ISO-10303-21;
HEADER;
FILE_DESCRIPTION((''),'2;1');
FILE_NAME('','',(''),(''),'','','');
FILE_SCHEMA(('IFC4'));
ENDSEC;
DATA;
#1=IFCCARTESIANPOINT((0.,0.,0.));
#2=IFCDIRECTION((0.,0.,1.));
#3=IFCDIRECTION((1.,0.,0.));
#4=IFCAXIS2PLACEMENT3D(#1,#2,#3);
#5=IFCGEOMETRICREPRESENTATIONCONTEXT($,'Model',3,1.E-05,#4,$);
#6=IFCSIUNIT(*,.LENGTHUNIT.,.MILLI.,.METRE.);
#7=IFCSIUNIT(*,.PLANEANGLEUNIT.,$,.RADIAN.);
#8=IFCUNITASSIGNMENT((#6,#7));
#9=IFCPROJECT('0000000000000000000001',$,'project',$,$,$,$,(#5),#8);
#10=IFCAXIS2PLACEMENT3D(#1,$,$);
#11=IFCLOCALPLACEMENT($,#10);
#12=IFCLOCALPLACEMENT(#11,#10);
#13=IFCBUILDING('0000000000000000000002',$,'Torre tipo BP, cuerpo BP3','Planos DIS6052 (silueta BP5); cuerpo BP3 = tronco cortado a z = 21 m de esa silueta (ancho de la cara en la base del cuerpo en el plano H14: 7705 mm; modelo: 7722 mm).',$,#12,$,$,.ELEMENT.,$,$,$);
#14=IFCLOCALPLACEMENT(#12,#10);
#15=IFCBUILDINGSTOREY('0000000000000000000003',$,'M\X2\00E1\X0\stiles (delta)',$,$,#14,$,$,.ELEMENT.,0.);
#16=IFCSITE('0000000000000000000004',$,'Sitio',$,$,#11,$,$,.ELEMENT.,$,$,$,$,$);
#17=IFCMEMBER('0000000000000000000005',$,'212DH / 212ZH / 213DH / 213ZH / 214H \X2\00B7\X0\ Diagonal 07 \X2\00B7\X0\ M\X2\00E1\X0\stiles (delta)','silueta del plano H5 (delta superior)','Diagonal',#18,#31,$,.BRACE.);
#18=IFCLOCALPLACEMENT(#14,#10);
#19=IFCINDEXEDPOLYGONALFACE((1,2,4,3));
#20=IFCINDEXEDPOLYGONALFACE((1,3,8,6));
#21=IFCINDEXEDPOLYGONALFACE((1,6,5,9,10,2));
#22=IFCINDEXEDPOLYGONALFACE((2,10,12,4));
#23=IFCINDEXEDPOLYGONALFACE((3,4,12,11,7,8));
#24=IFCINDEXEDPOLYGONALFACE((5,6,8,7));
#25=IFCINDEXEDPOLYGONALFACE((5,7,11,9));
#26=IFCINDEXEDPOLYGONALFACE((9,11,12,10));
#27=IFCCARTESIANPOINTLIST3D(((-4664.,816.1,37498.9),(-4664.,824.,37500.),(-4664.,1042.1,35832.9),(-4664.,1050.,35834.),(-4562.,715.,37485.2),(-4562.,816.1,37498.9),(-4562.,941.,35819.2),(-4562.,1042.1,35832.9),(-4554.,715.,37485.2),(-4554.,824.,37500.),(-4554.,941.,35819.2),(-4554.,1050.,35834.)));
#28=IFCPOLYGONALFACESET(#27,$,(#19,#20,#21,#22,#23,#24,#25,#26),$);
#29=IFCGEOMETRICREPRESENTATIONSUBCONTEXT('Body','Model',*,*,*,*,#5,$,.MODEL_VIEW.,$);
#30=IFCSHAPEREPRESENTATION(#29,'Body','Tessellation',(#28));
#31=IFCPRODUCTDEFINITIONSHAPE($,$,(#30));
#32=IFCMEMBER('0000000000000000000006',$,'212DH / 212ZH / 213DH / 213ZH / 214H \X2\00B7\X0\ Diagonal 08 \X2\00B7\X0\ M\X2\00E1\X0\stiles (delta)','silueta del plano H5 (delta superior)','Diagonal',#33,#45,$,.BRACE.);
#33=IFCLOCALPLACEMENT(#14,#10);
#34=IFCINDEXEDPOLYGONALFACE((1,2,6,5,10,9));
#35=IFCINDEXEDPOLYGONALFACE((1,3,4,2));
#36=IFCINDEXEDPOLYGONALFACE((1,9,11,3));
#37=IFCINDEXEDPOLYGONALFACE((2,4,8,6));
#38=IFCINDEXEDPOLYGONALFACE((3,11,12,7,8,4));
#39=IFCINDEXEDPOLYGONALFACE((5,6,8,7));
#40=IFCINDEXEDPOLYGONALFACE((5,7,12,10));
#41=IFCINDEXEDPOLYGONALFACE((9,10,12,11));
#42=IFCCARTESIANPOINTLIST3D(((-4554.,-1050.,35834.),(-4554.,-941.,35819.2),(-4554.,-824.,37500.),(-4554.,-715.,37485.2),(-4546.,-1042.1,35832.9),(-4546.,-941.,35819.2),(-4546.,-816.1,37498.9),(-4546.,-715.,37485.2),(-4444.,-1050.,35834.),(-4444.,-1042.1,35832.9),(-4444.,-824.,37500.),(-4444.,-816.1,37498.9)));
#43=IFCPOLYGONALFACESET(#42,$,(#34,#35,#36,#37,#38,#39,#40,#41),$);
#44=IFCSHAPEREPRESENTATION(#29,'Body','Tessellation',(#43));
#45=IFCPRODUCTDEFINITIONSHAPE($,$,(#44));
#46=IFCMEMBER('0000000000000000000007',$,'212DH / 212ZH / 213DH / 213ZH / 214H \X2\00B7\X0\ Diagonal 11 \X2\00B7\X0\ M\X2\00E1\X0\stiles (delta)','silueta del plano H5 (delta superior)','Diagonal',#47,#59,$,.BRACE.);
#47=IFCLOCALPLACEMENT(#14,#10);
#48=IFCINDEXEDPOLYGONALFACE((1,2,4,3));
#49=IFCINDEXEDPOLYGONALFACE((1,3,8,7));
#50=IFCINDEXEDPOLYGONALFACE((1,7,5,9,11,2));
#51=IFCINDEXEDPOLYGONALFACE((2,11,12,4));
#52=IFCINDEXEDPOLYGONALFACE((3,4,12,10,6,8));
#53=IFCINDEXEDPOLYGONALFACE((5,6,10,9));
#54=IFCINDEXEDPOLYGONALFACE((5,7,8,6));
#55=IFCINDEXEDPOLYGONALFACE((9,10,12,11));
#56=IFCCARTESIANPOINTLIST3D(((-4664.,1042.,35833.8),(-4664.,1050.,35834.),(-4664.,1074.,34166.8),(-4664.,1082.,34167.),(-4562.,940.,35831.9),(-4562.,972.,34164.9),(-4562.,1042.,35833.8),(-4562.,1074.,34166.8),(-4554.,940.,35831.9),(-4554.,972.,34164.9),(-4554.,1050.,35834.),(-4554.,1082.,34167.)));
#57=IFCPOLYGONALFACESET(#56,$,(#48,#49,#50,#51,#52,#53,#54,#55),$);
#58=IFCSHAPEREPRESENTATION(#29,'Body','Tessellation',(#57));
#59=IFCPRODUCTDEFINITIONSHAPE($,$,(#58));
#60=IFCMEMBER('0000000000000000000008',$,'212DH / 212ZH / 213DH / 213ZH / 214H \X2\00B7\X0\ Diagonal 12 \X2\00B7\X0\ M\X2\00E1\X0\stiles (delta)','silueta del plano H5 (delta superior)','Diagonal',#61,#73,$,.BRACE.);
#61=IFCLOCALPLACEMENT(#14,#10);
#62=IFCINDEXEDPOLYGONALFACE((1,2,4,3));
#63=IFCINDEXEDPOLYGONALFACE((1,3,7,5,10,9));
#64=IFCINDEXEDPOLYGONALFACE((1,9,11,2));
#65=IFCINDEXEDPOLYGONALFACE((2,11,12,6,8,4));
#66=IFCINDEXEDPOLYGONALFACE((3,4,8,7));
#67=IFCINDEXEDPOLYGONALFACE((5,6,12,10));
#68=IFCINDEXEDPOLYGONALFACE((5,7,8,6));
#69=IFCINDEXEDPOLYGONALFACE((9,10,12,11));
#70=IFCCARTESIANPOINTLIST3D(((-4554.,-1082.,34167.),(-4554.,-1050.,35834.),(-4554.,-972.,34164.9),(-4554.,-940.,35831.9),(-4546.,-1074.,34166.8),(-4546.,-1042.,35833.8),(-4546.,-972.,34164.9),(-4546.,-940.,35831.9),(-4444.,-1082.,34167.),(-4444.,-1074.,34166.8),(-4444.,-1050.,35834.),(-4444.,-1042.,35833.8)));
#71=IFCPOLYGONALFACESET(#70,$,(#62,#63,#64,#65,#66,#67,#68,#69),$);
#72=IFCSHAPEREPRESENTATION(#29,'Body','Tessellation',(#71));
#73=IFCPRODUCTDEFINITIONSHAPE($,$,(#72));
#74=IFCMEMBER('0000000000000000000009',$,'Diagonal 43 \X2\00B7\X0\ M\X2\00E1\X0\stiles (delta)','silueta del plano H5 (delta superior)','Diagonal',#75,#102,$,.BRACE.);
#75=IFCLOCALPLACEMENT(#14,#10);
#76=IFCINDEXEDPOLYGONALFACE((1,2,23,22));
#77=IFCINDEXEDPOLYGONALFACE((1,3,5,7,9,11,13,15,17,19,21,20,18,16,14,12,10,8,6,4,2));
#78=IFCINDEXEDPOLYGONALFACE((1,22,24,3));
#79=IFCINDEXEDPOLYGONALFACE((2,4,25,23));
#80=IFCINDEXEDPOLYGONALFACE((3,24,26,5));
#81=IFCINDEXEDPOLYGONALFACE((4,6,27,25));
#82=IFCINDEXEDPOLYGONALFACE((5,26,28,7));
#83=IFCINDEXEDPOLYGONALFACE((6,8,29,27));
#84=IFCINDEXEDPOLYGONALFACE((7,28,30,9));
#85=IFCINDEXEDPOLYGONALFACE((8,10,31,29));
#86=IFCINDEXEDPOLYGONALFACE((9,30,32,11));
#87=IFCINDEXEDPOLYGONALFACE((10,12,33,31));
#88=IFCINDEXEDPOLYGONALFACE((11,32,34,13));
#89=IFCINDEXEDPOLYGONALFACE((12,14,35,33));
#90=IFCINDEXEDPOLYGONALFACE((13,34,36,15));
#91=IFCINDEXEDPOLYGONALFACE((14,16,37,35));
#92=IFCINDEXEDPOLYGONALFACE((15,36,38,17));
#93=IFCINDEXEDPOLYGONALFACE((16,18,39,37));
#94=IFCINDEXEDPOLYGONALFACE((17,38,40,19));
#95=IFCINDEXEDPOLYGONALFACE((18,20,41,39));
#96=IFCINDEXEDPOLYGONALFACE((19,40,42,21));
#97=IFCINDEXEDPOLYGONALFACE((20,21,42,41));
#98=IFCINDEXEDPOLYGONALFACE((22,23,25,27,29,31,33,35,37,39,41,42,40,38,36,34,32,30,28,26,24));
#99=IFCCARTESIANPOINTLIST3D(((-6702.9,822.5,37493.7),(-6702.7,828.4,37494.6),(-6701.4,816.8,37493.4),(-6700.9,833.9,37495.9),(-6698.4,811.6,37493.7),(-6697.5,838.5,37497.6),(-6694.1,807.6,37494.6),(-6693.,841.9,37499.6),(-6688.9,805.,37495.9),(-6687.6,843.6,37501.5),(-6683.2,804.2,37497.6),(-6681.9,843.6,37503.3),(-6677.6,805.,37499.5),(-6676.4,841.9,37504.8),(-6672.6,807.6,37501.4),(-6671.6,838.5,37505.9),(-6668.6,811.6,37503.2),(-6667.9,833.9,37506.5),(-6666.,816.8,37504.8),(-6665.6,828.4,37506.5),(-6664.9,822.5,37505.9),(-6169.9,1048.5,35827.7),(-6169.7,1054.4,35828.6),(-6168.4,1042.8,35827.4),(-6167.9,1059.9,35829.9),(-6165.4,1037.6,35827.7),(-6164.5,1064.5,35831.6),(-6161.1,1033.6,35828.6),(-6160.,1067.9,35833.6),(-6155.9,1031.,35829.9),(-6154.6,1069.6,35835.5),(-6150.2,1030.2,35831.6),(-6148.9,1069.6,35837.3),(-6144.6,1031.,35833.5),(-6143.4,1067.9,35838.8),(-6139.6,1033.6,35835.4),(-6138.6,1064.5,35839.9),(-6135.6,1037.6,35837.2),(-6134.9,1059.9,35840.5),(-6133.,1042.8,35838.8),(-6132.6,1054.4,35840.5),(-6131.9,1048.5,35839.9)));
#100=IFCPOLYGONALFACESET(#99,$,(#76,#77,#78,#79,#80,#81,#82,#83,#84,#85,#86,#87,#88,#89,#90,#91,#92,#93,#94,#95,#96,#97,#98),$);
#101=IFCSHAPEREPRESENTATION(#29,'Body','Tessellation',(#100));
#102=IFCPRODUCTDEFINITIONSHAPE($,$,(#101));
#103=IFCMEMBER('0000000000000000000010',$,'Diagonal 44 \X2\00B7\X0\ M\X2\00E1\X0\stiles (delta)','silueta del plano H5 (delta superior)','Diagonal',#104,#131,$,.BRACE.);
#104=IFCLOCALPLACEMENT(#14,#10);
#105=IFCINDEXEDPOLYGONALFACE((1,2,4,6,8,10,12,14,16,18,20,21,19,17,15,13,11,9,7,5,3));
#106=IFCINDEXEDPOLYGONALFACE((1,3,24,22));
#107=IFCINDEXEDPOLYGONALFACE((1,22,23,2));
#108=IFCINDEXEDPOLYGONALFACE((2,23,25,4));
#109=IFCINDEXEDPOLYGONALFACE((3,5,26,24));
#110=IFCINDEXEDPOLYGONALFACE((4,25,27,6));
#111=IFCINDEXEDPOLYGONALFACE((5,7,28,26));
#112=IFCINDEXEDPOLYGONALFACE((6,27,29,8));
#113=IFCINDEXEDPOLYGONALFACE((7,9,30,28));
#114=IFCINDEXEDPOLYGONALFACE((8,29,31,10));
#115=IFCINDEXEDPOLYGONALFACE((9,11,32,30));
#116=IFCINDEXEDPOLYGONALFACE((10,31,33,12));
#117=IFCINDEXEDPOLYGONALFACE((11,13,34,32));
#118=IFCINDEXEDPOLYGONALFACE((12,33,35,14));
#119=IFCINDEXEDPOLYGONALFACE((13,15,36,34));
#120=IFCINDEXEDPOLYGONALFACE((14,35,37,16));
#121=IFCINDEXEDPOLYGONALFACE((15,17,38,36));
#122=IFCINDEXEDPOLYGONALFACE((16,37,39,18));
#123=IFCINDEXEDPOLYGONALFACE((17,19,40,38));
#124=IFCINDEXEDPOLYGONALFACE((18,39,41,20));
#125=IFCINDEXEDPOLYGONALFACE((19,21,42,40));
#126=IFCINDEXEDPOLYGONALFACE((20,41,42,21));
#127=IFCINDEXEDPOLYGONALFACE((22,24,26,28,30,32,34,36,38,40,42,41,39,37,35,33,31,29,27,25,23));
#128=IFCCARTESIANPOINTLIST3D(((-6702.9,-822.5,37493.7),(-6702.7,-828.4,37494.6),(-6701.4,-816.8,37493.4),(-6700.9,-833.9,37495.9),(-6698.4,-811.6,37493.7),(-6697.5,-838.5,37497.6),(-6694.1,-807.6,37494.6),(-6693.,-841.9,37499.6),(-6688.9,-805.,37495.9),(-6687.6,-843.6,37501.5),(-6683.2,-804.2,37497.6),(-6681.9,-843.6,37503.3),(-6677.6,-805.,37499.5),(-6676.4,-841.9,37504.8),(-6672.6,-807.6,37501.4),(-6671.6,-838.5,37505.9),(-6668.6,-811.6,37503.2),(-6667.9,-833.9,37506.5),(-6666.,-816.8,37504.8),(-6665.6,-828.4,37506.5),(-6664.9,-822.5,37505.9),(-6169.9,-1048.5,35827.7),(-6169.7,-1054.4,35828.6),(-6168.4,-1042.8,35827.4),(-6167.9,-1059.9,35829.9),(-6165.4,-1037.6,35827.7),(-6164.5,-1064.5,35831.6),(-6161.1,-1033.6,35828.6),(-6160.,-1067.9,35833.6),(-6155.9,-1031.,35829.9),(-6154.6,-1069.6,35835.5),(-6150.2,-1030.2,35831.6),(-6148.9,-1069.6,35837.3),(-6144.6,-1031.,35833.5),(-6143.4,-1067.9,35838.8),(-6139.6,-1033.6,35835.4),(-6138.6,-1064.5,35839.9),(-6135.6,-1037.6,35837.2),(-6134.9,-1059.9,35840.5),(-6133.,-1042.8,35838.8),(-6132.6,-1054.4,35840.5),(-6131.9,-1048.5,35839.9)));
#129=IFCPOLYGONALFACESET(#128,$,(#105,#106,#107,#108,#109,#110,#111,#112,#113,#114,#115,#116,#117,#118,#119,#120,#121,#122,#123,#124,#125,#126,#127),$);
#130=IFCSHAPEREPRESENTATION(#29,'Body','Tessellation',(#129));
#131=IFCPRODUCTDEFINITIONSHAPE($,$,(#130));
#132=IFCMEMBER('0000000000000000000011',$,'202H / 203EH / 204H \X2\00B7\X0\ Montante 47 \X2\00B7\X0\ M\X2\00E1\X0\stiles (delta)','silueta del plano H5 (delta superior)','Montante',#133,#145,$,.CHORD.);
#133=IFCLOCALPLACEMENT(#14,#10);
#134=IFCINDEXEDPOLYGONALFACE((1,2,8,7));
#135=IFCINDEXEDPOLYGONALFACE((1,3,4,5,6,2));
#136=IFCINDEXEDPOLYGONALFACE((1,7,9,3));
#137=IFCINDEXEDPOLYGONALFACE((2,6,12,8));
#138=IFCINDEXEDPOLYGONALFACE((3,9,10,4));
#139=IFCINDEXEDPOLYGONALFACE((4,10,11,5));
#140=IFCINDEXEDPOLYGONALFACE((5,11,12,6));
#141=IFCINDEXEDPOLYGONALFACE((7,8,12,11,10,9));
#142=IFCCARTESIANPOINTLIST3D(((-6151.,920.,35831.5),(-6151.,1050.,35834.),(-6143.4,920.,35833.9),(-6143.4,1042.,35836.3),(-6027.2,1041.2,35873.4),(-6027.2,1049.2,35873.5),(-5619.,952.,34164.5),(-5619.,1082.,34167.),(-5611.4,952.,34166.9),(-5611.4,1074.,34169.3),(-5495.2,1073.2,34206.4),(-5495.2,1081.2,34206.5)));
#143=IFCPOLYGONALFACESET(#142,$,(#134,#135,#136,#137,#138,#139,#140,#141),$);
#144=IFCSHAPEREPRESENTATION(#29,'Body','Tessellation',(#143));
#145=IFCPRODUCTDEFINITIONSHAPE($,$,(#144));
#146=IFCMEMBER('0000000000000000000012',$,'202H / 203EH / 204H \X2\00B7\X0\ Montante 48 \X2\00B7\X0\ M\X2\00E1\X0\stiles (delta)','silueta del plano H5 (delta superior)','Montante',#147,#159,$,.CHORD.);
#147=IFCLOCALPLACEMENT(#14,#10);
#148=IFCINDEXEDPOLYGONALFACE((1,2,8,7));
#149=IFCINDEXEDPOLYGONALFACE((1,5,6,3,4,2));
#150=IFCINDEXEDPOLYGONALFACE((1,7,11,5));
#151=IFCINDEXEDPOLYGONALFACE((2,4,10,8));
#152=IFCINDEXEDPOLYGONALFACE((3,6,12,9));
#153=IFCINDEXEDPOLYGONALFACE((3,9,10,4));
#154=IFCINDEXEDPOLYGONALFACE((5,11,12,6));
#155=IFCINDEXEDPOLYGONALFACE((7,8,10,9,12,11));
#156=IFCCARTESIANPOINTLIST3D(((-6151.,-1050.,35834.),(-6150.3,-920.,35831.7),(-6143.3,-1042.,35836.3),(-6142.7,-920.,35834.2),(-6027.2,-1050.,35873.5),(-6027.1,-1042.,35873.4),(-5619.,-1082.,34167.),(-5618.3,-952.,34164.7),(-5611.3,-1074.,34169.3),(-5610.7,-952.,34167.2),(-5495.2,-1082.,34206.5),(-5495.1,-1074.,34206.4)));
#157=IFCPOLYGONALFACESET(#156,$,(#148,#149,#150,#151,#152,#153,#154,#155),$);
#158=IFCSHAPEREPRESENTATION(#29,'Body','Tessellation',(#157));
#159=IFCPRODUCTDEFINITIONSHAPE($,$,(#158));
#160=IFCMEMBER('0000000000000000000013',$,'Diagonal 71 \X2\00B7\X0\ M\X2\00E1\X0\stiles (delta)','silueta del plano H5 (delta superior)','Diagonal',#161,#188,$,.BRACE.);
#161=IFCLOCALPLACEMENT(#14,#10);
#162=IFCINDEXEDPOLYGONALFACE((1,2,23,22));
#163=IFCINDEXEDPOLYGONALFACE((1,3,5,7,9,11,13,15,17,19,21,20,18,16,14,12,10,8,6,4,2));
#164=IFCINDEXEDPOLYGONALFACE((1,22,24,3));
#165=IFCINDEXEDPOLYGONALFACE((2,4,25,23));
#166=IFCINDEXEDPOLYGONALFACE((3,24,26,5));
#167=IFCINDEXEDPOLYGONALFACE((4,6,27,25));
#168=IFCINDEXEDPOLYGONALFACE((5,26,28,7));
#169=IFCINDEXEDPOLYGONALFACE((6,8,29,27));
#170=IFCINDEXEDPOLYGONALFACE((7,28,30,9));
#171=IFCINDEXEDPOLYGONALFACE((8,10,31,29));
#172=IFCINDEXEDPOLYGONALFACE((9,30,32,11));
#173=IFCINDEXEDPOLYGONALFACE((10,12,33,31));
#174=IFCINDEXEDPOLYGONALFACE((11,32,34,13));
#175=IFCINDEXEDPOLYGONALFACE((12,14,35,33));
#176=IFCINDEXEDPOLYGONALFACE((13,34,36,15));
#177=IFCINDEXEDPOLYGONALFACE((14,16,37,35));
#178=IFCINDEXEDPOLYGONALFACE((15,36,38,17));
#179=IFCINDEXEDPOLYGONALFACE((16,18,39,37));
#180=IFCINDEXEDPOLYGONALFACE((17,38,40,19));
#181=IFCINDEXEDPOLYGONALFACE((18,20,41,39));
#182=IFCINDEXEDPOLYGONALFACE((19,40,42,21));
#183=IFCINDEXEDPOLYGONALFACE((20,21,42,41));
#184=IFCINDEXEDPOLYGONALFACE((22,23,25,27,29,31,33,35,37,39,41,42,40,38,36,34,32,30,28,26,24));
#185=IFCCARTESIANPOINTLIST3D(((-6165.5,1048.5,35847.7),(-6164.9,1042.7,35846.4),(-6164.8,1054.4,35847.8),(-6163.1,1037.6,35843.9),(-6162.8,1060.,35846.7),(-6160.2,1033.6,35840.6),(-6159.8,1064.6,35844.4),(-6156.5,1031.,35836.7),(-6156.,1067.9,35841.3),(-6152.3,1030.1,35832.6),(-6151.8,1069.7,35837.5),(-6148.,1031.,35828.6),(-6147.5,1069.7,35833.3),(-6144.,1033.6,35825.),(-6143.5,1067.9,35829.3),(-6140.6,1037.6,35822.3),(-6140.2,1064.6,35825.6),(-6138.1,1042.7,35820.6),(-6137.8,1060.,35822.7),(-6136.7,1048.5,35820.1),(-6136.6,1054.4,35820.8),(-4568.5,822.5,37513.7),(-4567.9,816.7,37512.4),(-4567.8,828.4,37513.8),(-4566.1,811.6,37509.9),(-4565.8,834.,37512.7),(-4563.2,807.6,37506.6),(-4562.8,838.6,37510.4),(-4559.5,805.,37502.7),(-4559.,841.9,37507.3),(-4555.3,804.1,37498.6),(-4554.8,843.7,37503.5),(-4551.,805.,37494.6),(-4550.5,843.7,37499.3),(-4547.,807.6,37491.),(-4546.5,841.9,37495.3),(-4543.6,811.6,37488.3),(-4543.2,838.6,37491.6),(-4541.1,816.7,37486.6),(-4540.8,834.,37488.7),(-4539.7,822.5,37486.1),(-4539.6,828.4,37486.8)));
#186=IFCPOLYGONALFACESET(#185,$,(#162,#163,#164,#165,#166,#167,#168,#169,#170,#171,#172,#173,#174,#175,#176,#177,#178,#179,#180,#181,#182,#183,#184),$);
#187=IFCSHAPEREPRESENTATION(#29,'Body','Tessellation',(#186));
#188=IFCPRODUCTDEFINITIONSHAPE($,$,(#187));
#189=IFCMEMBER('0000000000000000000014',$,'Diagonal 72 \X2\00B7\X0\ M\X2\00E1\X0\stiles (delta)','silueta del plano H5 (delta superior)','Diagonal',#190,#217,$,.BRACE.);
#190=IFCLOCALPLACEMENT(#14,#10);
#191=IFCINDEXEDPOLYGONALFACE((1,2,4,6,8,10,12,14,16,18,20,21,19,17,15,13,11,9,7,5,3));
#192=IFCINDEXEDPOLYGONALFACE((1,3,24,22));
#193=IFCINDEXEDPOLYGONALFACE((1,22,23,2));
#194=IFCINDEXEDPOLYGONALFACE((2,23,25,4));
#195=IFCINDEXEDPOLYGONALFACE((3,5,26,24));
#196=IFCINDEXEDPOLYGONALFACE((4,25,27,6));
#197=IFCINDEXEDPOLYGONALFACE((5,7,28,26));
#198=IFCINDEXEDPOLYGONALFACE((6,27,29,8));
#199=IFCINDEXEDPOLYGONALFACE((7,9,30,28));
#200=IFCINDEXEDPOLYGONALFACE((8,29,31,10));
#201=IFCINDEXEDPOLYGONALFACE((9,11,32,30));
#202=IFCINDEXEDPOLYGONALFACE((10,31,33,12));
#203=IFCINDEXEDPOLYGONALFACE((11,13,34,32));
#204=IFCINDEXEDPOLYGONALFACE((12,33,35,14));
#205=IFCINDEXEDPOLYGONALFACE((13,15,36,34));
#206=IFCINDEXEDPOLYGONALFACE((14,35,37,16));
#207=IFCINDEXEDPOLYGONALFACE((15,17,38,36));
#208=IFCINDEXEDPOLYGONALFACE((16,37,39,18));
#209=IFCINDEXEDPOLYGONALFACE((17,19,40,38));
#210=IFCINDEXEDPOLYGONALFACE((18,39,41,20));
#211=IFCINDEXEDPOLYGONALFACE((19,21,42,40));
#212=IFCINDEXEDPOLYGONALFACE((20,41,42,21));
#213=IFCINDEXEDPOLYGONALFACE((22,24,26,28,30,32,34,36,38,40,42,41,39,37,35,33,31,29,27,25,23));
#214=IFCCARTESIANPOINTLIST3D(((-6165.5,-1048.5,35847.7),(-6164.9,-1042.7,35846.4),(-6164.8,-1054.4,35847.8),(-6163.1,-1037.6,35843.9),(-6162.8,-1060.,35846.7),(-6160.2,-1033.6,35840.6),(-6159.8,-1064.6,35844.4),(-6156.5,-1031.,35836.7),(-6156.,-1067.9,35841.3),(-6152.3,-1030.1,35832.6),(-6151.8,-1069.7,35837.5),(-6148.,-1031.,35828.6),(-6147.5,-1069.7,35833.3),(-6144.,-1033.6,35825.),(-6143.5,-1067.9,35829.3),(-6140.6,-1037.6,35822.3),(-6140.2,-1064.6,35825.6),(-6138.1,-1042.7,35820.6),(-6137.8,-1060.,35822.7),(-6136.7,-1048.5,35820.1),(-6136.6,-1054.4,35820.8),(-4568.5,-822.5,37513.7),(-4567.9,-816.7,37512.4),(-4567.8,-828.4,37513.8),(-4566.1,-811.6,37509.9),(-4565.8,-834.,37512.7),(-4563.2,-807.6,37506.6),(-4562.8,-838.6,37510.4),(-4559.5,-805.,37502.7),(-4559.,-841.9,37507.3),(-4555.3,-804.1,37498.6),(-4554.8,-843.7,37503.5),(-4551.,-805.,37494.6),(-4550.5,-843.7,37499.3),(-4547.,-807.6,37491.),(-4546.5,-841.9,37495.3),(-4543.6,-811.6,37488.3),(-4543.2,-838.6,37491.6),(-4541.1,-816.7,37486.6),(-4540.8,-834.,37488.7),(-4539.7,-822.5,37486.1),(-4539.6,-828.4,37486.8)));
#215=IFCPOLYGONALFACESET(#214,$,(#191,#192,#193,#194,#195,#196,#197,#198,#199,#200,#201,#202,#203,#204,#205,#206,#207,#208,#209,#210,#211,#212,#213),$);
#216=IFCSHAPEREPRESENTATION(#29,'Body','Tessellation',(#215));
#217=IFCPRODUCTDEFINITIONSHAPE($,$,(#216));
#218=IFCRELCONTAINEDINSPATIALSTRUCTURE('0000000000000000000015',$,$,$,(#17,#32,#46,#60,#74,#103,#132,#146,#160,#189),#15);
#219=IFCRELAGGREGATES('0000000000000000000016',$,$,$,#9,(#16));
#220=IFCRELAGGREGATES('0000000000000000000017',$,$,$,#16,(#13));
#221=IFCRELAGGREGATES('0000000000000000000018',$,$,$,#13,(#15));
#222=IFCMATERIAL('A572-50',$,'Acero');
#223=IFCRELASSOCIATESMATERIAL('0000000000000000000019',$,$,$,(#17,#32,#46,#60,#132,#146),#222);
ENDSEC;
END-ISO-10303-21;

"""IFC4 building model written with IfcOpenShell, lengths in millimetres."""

from ifc_helpers import new_model, si_unit, frame, frame_2d, origin, origin_with_axes, place, context, subcontext, project, spatial, circle, l_section, extrude, material, element, save


model = new_model("IFC4")

# Units and contexts
model_context = context("Model", 3, precision=1e-05, world=origin_with_axes())
body_context = subcontext(model_context, "Body", "Model", "MODEL_VIEW")
ifc_project = project(units=[si_unit("LENGTHUNIT", "METRE", prefix="MILLI"), si_unit("PLANEANGLEUNIT", "RADIAN")], contexts=[model_context])

# Site, building, storey
site_placement = place(None, origin())
site = spatial("IfcSite", under=ifc_project, at=site_placement, Name="Sitio", CompositionType="ELEMENT")
building_placement = place(site_placement, origin())
building = spatial("IfcBuilding", under=site, at=building_placement, Name="Torre tipo BP, cuerpo BP3", Description="Planos DIS6052 (silueta BP5); cuerpo BP3 = tronco cortado a z = 21 m de esa silueta (ancho de la cara en la base del cuerpo en el plano H14: 7705 mm; modelo: 7722 mm).", CompositionType="ELEMENT")
storey_placement = place(building_placement, origin())
storey = spatial("IfcBuildingStorey", under=building, at=storey_placement, Name="Mástiles (delta)", CompositionType="ELEMENT", Elevation=0.0)

# Members
ifc_material = material(Name="A572-50", Category="Acero")
for number, where, z_axis, x_axis, name in (
    (1, (-4554.0, 824.0, 37500.0), (0.0, 0.134423, -0.990924), (0.0, -0.990924, -0.134423), "212DH / 212ZH / 213DH / 213ZH / 214H · Diagonal 07 · Mástiles (delta)"),
    (2, (-4554.0, -824.0, 37500.0), (0.0, -0.134423, -0.990924), (0.0, 0.990924, -0.134423), "212DH / 212ZH / 213DH / 213ZH / 214H · Diagonal 08 · Mástiles (delta)"),
):
    element("IfcMember", number, at=place(storey_placement, frame(where, z_axis=z_axis, x_axis=x_axis)), inside=storey, material=ifc_material, Name=name, Description="silueta del plano H5 (delta superior)", ObjectType="Diagonal", PredefinedType="BRACE", context=body_context, shape_type="SweptSolid", body=[
        extrude(l_section(Depth=110.0, Width=110.0, Thickness=8.0, at=frame_2d((55.0, 55.0))), None, (0.0, 0.0, 1.0), 1681.3),
    ])
for number, where, z_axis, x_axis, name in (
    (3, (-4554.0, 1050.0, 35834.0), (0.0, 0.019193, -0.999816), (0.0, -0.999816, -0.019193), "212DH / 212ZH / 213DH / 213ZH / 214H · Diagonal 11 · Mástiles (delta)"),
    (4, (-4554.0, -1050.0, 35834.0), (0.0, -0.019193, -0.999816), (0.0, 0.999816, -0.019193), "212DH / 212ZH / 213DH / 213ZH / 214H · Diagonal 12 · Mástiles (delta)"),
):
    element("IfcMember", number, at=place(storey_placement, frame(where, z_axis=z_axis, x_axis=x_axis)), inside=storey, material=ifc_material, Name=name, Description="silueta del plano H5 (delta superior)", ObjectType="Diagonal", PredefinedType="BRACE", context=body_context, shape_type="SweptSolid", body=[
        extrude(l_section(Depth=110.0, Width=110.0, Thickness=8.0, at=frame_2d((55.0, 55.0))), None, (0.0, 0.0, 1.0), 1667.3),
    ])
for number, where, z_axis, x_axis, name in (
    (5, (-6684.0, 824.0, 37500.0), (0.302202, 0.128138, -0.944592), (0.039045, -0.991756, -0.122044), "Diagonal 43 · Mástiles (delta)"),
    (6, (-6684.0, -824.0, 37500.0), (0.302202, -0.128138, -0.944592), (0.039045, 0.991756, -0.122044), "Diagonal 44 · Mástiles (delta)"),
):
    element("IfcMember", number, at=place(storey_placement, frame(where, z_axis=z_axis, x_axis=x_axis)), inside=storey, Name=name, Description="silueta del plano H5 (delta superior)", ObjectType="Diagonal", PredefinedType="BRACE", context=body_context, shape_type="SweptSolid", body=[
        extrude(circle(Radius=20.0), None, (0.0, 0.0, 1.0), 1763.7),
    ])
for number, where, z_axis, x_axis, name in (
    (7, (-6151.0, 1050.0, 35834.0), (0.303978, 0.018284, -0.952503), (0.952679, -0.005834, 0.303922), "202H / 203EH / 204H · Montante 47 · Mástiles (delta)"),
    (8, (-6151.0, -1050.0, 35834.0), (0.303978, -0.018284, -0.952503), (0.005559, 0.999833, -0.017419), "202H / 203EH / 204H · Montante 48 · Mástiles (delta)"),
):
    element("IfcMember", number, at=place(storey_placement, frame(where, z_axis=z_axis, x_axis=x_axis)), inside=storey, material=ifc_material, Name=name, Description="silueta del plano H5 (delta superior)", ObjectType="Montante", PredefinedType="CHORD", context=body_context, shape_type="SweptSolid", body=[
        extrude(l_section(Depth=130.0, Width=130.0, Thickness=8.0, at=frame_2d((65.0, 65.0))), None, (0.0, 0.0, 1.0), 1750.1),
    ])
for number, where, z_axis, x_axis, name in (
    (9, (-4554.0, 824.0, 37500.0), (-0.688705, 0.097462, -0.718461), (-0.067444, -0.995239, -0.070358), "Diagonal 71 · Mástiles (delta)"),
    (10, (-4554.0, -824.0, 37500.0), (-0.688705, -0.097462, -0.718461), (-0.067444, 0.995239, -0.070358), "Diagonal 72 · Mástiles (delta)"),
):
    element("IfcMember", number, at=place(storey_placement, frame(where, z_axis=z_axis, x_axis=x_axis)), inside=storey, Name=name, Description="silueta del plano H5 (delta superior)", ObjectType="Diagonal", PredefinedType="BRACE", context=body_context, shape_type="SweptSolid", body=[
        extrude(circle(Radius=20.0), None, (0.0, 0.0, 1.0), 2318.8),
    ])

save(model, "model.ifc")
